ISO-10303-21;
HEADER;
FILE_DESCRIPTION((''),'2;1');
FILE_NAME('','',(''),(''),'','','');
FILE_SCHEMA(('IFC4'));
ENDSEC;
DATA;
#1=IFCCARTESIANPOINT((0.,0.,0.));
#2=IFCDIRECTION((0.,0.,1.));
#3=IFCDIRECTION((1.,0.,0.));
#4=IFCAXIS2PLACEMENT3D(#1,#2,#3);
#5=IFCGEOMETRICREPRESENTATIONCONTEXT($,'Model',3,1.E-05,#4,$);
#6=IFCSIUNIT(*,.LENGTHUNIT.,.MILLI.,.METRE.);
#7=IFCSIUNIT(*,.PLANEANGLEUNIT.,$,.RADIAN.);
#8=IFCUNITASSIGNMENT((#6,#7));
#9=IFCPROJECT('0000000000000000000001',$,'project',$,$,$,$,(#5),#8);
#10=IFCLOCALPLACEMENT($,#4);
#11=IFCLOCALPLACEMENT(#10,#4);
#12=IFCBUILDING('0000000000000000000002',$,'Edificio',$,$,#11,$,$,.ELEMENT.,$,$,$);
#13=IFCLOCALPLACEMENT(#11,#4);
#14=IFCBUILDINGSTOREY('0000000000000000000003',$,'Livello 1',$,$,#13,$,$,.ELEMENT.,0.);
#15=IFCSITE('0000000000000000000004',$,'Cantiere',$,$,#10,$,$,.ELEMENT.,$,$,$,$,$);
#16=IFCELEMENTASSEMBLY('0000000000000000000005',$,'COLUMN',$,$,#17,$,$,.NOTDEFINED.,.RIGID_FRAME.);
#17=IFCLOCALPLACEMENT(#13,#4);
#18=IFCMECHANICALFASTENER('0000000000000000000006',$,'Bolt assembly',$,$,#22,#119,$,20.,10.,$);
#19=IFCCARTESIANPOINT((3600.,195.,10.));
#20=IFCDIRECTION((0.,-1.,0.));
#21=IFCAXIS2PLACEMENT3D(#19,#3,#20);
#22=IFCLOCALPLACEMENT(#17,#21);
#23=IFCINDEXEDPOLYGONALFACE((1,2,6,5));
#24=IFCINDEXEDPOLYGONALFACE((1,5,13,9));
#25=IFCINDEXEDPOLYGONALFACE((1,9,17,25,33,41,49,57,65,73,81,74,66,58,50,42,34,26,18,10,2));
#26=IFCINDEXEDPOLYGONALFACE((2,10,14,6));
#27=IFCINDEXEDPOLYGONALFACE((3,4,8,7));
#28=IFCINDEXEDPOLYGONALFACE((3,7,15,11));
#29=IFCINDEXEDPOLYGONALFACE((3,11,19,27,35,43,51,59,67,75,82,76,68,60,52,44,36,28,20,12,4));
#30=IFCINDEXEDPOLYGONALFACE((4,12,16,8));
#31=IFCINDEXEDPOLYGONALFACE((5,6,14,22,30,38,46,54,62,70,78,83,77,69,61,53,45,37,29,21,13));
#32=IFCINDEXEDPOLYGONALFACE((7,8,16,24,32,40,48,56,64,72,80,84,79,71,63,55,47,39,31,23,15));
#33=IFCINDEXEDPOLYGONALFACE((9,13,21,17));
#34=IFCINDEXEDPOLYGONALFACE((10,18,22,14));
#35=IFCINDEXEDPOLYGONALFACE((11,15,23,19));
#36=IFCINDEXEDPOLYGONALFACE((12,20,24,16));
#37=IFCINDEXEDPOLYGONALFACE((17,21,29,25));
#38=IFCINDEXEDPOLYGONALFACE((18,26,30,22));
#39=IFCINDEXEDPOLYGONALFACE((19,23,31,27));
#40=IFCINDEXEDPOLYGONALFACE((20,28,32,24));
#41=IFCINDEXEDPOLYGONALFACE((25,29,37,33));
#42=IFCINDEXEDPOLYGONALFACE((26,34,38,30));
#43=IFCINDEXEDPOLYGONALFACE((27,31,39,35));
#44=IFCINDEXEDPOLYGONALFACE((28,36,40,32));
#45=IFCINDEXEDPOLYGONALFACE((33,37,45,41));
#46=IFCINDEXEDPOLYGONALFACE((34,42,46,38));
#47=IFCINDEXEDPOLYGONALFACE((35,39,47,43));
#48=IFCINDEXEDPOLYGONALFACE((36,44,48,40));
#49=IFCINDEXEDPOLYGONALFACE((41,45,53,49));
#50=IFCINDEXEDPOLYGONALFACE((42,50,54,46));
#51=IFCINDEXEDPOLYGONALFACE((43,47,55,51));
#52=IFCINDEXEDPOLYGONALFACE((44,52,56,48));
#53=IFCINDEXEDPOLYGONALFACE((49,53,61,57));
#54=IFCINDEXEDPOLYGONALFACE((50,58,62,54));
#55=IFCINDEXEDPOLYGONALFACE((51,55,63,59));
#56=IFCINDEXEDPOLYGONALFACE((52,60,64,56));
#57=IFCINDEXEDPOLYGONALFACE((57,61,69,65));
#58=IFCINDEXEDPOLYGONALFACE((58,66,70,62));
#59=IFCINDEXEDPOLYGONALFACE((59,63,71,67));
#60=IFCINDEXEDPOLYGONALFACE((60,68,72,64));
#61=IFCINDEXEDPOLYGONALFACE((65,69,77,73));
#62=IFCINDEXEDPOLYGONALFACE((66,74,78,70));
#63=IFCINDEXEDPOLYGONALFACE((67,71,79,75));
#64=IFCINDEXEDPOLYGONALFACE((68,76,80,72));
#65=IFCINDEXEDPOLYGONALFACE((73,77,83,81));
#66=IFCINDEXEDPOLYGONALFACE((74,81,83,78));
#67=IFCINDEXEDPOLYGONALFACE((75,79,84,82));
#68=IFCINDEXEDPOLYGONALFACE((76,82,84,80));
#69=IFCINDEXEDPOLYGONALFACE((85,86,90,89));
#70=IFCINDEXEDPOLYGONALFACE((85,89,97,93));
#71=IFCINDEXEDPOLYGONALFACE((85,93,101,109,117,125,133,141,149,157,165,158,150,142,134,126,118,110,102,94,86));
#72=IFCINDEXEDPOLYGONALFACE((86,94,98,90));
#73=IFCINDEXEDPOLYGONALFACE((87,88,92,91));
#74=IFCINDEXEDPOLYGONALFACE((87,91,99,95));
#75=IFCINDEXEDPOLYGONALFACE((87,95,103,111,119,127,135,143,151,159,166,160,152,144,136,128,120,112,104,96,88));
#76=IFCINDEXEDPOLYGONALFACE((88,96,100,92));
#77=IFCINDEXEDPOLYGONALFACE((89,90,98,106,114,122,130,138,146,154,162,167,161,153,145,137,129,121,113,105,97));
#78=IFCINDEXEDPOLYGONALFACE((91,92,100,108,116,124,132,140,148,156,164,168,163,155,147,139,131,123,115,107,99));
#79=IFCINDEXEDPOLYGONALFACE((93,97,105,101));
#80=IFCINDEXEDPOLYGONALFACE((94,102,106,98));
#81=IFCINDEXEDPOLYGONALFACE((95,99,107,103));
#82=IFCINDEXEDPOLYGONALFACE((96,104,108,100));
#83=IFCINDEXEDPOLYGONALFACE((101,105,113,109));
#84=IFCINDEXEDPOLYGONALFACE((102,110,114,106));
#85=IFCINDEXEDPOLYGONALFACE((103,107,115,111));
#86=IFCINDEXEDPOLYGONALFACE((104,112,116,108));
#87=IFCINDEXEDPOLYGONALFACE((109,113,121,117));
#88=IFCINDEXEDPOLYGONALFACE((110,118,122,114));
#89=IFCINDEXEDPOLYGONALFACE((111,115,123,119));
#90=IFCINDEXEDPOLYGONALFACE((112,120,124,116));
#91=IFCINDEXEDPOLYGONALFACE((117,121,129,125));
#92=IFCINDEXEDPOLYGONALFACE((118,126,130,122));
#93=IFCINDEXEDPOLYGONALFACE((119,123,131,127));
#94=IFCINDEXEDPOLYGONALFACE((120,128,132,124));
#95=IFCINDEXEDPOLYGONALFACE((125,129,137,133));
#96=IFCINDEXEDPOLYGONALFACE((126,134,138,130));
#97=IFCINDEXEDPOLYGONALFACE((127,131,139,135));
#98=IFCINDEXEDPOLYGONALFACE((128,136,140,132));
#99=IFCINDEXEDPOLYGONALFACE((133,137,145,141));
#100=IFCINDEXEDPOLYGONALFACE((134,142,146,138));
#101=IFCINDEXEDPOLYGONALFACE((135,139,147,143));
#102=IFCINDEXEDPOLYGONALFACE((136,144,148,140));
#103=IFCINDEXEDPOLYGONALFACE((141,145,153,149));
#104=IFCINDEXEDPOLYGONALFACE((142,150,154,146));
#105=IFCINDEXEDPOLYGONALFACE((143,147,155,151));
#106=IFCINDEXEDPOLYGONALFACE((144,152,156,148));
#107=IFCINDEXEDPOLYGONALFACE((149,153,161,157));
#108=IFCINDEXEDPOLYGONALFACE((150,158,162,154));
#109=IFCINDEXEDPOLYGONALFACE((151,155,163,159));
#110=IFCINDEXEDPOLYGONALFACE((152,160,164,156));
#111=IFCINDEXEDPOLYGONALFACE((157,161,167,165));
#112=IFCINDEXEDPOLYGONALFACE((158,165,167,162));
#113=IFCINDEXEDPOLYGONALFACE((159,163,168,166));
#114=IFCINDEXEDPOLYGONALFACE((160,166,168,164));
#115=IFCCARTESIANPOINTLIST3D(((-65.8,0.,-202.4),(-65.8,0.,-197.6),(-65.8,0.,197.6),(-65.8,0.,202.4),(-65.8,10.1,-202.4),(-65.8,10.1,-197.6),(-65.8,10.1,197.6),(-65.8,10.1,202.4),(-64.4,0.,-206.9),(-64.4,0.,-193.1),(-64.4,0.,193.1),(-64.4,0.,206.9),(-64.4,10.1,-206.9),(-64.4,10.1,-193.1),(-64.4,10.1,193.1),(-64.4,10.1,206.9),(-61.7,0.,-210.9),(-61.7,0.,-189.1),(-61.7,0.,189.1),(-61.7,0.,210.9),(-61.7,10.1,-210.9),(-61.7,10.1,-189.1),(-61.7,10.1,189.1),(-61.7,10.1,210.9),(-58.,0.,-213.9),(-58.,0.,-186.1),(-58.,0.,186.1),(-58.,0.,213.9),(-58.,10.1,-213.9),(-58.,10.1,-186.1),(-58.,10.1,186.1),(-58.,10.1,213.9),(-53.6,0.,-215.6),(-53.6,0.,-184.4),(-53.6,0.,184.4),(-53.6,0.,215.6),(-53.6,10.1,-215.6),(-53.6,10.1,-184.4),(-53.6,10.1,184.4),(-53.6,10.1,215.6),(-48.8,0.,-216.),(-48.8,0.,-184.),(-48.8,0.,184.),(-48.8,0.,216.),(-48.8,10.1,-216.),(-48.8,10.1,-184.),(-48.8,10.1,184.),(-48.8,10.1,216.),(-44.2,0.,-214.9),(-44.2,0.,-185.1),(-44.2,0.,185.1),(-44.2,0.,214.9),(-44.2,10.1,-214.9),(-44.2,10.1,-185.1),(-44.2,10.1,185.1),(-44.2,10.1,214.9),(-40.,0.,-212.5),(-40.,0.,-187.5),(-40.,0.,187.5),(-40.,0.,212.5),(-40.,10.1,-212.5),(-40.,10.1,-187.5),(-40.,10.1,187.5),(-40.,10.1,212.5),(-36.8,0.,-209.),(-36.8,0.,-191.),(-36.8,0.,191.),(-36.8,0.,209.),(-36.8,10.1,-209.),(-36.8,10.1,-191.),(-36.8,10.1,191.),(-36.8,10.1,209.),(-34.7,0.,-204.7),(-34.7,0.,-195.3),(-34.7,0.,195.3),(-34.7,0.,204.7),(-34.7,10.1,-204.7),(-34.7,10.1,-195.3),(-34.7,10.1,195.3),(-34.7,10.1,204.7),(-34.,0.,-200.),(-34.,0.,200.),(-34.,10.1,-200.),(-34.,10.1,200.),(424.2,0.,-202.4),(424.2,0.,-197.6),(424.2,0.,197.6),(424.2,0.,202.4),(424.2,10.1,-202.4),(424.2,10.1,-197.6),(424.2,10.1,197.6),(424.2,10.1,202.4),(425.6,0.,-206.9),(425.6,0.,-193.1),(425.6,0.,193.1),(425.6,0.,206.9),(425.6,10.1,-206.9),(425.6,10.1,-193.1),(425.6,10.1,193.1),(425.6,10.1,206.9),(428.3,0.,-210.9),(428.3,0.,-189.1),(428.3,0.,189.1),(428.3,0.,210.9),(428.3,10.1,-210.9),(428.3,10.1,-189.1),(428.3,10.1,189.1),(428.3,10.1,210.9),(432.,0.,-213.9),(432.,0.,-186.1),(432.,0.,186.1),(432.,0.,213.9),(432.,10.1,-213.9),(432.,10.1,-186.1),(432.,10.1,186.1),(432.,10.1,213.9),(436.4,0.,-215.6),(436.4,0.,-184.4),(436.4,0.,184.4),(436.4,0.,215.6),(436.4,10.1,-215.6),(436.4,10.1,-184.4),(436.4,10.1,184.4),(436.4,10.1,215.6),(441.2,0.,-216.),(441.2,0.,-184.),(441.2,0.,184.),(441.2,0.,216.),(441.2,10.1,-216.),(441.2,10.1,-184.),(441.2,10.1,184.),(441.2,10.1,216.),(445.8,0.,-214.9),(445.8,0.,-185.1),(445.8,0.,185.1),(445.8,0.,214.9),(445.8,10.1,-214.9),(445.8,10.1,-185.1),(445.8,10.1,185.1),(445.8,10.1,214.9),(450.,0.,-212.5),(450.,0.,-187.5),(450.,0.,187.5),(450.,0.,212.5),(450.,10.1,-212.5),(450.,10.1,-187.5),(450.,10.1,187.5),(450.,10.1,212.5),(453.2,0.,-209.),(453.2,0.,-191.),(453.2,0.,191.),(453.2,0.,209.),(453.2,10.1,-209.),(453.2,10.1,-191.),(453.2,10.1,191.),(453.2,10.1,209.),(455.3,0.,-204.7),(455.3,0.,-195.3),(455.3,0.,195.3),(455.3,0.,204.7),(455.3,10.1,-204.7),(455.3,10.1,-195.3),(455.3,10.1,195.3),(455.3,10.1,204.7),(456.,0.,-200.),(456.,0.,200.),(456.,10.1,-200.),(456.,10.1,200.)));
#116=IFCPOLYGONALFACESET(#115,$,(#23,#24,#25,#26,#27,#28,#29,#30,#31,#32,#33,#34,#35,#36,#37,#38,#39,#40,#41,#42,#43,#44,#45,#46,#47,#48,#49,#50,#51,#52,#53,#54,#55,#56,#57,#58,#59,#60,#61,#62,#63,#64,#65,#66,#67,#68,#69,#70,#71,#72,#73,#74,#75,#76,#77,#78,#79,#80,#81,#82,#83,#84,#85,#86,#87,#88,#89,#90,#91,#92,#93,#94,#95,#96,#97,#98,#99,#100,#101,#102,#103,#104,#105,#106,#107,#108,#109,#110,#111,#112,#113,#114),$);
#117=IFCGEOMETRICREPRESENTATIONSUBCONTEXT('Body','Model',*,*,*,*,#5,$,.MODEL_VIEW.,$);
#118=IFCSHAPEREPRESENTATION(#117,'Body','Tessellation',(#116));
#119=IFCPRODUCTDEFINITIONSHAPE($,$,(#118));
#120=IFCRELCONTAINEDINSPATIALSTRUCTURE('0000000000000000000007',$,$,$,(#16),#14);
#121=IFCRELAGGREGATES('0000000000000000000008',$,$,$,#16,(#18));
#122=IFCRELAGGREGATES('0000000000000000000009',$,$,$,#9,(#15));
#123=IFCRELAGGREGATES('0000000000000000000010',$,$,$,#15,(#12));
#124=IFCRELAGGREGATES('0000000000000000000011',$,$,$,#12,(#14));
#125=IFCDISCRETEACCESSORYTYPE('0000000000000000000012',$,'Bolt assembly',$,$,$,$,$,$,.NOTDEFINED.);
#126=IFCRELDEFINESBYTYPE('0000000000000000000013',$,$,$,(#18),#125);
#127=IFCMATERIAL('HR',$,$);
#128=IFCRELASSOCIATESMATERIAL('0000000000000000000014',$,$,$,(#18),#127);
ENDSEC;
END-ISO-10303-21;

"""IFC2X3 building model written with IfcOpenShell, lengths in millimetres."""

from ifc_helpers import new_model, si_unit, frame, origin_with_axes, origin_2d_with_axis, place, context, subcontext, project, spatial, circle, extrude, source, transform, mapped, material, type_object, element, aggregate, save


model = new_model("IFC2X3")

# Units and contexts
model_context = context("Model", 3, precision=1e-05, world=origin_with_axes())
body_context = subcontext(model_context, "Body", "Model", "MODEL_VIEW")
ifc_project = project(units=[si_unit("LENGTHUNIT", "METRE", prefix="MILLI"), si_unit("PLANEANGLEUNIT", "RADIAN")], contexts=[model_context])

# Site, building, storey
site_placement = place(None, origin_with_axes())
site = spatial("IfcSite", under=ifc_project, at=site_placement, Name="Cantiere", CompositionType="ELEMENT")
building_placement = place(site_placement, origin_with_axes())
building = spatial("IfcBuilding", under=site, at=building_placement, Name="Edificio", CompositionType="ELEMENT")
storey_placement = place(building_placement, origin_with_axes())
storey = spatial("IfcBuildingStorey", under=building, at=storey_placement, Name="Livello 1", CompositionType="ELEMENT", Elevation=0.0)

# Element assembly
assembly_1_placement = place(storey_placement, origin_with_axes())
assembly_1 = element("IfcElementAssembly", 1, at=assembly_1_placement, inside=storey, Name="COLUMN", AssemblyPlace="NOTDEFINED", PredefinedType="RIGID_FRAME")

# Mechanical fastener
ifc_material_1 = material(Name="HR")
discrete_accessory_type_1 = type_object("IfcDiscreteAccessoryType", Name="Bolt assembly")
shared_shape_1 = source(origin_with_axes(), body_context, "Body", "SweptSolid", [
    extrude(circle(Radius=16.0, at=origin_2d_with_axis()), frame((0.0, 0.0, 0.0), z_axis=(0.0, 1.0, 0.0), x_axis=(1.0, 0.0, 0.0)), (0.0, 0.0, 1.0), 10.1),
])
mechanical_fastener_1_placement = place(assembly_1_placement, frame((3600.0, 195.0, 10.0), z_axis=(1.0, 0.0, 0.0), x_axis=(0.0, -1.0, 0.0)))
mechanical_fastener_1 = element("IfcMechanicalFastener", 2, at=mechanical_fastener_1_placement, type_object=discrete_accessory_type_1, material=ifc_material_1, Name="Bolt assembly", NominalDiameter=20.0, NominalLength=10.0, context=body_context, shape_type="MappedRepresentation", body=[
    mapped(shared_shape_1, transform((-50.0, 0.0, -200.0))),
    mapped(shared_shape_1, transform((-50.0, 0.0, 200.0))),
    mapped(shared_shape_1, transform((440.0, 0.0, -200.0))),
    mapped(shared_shape_1, transform((440.0, 0.0, 200.0))),
])

aggregate(assembly_1, [mechanical_fastener_1])

save(model, "model.ifc")
